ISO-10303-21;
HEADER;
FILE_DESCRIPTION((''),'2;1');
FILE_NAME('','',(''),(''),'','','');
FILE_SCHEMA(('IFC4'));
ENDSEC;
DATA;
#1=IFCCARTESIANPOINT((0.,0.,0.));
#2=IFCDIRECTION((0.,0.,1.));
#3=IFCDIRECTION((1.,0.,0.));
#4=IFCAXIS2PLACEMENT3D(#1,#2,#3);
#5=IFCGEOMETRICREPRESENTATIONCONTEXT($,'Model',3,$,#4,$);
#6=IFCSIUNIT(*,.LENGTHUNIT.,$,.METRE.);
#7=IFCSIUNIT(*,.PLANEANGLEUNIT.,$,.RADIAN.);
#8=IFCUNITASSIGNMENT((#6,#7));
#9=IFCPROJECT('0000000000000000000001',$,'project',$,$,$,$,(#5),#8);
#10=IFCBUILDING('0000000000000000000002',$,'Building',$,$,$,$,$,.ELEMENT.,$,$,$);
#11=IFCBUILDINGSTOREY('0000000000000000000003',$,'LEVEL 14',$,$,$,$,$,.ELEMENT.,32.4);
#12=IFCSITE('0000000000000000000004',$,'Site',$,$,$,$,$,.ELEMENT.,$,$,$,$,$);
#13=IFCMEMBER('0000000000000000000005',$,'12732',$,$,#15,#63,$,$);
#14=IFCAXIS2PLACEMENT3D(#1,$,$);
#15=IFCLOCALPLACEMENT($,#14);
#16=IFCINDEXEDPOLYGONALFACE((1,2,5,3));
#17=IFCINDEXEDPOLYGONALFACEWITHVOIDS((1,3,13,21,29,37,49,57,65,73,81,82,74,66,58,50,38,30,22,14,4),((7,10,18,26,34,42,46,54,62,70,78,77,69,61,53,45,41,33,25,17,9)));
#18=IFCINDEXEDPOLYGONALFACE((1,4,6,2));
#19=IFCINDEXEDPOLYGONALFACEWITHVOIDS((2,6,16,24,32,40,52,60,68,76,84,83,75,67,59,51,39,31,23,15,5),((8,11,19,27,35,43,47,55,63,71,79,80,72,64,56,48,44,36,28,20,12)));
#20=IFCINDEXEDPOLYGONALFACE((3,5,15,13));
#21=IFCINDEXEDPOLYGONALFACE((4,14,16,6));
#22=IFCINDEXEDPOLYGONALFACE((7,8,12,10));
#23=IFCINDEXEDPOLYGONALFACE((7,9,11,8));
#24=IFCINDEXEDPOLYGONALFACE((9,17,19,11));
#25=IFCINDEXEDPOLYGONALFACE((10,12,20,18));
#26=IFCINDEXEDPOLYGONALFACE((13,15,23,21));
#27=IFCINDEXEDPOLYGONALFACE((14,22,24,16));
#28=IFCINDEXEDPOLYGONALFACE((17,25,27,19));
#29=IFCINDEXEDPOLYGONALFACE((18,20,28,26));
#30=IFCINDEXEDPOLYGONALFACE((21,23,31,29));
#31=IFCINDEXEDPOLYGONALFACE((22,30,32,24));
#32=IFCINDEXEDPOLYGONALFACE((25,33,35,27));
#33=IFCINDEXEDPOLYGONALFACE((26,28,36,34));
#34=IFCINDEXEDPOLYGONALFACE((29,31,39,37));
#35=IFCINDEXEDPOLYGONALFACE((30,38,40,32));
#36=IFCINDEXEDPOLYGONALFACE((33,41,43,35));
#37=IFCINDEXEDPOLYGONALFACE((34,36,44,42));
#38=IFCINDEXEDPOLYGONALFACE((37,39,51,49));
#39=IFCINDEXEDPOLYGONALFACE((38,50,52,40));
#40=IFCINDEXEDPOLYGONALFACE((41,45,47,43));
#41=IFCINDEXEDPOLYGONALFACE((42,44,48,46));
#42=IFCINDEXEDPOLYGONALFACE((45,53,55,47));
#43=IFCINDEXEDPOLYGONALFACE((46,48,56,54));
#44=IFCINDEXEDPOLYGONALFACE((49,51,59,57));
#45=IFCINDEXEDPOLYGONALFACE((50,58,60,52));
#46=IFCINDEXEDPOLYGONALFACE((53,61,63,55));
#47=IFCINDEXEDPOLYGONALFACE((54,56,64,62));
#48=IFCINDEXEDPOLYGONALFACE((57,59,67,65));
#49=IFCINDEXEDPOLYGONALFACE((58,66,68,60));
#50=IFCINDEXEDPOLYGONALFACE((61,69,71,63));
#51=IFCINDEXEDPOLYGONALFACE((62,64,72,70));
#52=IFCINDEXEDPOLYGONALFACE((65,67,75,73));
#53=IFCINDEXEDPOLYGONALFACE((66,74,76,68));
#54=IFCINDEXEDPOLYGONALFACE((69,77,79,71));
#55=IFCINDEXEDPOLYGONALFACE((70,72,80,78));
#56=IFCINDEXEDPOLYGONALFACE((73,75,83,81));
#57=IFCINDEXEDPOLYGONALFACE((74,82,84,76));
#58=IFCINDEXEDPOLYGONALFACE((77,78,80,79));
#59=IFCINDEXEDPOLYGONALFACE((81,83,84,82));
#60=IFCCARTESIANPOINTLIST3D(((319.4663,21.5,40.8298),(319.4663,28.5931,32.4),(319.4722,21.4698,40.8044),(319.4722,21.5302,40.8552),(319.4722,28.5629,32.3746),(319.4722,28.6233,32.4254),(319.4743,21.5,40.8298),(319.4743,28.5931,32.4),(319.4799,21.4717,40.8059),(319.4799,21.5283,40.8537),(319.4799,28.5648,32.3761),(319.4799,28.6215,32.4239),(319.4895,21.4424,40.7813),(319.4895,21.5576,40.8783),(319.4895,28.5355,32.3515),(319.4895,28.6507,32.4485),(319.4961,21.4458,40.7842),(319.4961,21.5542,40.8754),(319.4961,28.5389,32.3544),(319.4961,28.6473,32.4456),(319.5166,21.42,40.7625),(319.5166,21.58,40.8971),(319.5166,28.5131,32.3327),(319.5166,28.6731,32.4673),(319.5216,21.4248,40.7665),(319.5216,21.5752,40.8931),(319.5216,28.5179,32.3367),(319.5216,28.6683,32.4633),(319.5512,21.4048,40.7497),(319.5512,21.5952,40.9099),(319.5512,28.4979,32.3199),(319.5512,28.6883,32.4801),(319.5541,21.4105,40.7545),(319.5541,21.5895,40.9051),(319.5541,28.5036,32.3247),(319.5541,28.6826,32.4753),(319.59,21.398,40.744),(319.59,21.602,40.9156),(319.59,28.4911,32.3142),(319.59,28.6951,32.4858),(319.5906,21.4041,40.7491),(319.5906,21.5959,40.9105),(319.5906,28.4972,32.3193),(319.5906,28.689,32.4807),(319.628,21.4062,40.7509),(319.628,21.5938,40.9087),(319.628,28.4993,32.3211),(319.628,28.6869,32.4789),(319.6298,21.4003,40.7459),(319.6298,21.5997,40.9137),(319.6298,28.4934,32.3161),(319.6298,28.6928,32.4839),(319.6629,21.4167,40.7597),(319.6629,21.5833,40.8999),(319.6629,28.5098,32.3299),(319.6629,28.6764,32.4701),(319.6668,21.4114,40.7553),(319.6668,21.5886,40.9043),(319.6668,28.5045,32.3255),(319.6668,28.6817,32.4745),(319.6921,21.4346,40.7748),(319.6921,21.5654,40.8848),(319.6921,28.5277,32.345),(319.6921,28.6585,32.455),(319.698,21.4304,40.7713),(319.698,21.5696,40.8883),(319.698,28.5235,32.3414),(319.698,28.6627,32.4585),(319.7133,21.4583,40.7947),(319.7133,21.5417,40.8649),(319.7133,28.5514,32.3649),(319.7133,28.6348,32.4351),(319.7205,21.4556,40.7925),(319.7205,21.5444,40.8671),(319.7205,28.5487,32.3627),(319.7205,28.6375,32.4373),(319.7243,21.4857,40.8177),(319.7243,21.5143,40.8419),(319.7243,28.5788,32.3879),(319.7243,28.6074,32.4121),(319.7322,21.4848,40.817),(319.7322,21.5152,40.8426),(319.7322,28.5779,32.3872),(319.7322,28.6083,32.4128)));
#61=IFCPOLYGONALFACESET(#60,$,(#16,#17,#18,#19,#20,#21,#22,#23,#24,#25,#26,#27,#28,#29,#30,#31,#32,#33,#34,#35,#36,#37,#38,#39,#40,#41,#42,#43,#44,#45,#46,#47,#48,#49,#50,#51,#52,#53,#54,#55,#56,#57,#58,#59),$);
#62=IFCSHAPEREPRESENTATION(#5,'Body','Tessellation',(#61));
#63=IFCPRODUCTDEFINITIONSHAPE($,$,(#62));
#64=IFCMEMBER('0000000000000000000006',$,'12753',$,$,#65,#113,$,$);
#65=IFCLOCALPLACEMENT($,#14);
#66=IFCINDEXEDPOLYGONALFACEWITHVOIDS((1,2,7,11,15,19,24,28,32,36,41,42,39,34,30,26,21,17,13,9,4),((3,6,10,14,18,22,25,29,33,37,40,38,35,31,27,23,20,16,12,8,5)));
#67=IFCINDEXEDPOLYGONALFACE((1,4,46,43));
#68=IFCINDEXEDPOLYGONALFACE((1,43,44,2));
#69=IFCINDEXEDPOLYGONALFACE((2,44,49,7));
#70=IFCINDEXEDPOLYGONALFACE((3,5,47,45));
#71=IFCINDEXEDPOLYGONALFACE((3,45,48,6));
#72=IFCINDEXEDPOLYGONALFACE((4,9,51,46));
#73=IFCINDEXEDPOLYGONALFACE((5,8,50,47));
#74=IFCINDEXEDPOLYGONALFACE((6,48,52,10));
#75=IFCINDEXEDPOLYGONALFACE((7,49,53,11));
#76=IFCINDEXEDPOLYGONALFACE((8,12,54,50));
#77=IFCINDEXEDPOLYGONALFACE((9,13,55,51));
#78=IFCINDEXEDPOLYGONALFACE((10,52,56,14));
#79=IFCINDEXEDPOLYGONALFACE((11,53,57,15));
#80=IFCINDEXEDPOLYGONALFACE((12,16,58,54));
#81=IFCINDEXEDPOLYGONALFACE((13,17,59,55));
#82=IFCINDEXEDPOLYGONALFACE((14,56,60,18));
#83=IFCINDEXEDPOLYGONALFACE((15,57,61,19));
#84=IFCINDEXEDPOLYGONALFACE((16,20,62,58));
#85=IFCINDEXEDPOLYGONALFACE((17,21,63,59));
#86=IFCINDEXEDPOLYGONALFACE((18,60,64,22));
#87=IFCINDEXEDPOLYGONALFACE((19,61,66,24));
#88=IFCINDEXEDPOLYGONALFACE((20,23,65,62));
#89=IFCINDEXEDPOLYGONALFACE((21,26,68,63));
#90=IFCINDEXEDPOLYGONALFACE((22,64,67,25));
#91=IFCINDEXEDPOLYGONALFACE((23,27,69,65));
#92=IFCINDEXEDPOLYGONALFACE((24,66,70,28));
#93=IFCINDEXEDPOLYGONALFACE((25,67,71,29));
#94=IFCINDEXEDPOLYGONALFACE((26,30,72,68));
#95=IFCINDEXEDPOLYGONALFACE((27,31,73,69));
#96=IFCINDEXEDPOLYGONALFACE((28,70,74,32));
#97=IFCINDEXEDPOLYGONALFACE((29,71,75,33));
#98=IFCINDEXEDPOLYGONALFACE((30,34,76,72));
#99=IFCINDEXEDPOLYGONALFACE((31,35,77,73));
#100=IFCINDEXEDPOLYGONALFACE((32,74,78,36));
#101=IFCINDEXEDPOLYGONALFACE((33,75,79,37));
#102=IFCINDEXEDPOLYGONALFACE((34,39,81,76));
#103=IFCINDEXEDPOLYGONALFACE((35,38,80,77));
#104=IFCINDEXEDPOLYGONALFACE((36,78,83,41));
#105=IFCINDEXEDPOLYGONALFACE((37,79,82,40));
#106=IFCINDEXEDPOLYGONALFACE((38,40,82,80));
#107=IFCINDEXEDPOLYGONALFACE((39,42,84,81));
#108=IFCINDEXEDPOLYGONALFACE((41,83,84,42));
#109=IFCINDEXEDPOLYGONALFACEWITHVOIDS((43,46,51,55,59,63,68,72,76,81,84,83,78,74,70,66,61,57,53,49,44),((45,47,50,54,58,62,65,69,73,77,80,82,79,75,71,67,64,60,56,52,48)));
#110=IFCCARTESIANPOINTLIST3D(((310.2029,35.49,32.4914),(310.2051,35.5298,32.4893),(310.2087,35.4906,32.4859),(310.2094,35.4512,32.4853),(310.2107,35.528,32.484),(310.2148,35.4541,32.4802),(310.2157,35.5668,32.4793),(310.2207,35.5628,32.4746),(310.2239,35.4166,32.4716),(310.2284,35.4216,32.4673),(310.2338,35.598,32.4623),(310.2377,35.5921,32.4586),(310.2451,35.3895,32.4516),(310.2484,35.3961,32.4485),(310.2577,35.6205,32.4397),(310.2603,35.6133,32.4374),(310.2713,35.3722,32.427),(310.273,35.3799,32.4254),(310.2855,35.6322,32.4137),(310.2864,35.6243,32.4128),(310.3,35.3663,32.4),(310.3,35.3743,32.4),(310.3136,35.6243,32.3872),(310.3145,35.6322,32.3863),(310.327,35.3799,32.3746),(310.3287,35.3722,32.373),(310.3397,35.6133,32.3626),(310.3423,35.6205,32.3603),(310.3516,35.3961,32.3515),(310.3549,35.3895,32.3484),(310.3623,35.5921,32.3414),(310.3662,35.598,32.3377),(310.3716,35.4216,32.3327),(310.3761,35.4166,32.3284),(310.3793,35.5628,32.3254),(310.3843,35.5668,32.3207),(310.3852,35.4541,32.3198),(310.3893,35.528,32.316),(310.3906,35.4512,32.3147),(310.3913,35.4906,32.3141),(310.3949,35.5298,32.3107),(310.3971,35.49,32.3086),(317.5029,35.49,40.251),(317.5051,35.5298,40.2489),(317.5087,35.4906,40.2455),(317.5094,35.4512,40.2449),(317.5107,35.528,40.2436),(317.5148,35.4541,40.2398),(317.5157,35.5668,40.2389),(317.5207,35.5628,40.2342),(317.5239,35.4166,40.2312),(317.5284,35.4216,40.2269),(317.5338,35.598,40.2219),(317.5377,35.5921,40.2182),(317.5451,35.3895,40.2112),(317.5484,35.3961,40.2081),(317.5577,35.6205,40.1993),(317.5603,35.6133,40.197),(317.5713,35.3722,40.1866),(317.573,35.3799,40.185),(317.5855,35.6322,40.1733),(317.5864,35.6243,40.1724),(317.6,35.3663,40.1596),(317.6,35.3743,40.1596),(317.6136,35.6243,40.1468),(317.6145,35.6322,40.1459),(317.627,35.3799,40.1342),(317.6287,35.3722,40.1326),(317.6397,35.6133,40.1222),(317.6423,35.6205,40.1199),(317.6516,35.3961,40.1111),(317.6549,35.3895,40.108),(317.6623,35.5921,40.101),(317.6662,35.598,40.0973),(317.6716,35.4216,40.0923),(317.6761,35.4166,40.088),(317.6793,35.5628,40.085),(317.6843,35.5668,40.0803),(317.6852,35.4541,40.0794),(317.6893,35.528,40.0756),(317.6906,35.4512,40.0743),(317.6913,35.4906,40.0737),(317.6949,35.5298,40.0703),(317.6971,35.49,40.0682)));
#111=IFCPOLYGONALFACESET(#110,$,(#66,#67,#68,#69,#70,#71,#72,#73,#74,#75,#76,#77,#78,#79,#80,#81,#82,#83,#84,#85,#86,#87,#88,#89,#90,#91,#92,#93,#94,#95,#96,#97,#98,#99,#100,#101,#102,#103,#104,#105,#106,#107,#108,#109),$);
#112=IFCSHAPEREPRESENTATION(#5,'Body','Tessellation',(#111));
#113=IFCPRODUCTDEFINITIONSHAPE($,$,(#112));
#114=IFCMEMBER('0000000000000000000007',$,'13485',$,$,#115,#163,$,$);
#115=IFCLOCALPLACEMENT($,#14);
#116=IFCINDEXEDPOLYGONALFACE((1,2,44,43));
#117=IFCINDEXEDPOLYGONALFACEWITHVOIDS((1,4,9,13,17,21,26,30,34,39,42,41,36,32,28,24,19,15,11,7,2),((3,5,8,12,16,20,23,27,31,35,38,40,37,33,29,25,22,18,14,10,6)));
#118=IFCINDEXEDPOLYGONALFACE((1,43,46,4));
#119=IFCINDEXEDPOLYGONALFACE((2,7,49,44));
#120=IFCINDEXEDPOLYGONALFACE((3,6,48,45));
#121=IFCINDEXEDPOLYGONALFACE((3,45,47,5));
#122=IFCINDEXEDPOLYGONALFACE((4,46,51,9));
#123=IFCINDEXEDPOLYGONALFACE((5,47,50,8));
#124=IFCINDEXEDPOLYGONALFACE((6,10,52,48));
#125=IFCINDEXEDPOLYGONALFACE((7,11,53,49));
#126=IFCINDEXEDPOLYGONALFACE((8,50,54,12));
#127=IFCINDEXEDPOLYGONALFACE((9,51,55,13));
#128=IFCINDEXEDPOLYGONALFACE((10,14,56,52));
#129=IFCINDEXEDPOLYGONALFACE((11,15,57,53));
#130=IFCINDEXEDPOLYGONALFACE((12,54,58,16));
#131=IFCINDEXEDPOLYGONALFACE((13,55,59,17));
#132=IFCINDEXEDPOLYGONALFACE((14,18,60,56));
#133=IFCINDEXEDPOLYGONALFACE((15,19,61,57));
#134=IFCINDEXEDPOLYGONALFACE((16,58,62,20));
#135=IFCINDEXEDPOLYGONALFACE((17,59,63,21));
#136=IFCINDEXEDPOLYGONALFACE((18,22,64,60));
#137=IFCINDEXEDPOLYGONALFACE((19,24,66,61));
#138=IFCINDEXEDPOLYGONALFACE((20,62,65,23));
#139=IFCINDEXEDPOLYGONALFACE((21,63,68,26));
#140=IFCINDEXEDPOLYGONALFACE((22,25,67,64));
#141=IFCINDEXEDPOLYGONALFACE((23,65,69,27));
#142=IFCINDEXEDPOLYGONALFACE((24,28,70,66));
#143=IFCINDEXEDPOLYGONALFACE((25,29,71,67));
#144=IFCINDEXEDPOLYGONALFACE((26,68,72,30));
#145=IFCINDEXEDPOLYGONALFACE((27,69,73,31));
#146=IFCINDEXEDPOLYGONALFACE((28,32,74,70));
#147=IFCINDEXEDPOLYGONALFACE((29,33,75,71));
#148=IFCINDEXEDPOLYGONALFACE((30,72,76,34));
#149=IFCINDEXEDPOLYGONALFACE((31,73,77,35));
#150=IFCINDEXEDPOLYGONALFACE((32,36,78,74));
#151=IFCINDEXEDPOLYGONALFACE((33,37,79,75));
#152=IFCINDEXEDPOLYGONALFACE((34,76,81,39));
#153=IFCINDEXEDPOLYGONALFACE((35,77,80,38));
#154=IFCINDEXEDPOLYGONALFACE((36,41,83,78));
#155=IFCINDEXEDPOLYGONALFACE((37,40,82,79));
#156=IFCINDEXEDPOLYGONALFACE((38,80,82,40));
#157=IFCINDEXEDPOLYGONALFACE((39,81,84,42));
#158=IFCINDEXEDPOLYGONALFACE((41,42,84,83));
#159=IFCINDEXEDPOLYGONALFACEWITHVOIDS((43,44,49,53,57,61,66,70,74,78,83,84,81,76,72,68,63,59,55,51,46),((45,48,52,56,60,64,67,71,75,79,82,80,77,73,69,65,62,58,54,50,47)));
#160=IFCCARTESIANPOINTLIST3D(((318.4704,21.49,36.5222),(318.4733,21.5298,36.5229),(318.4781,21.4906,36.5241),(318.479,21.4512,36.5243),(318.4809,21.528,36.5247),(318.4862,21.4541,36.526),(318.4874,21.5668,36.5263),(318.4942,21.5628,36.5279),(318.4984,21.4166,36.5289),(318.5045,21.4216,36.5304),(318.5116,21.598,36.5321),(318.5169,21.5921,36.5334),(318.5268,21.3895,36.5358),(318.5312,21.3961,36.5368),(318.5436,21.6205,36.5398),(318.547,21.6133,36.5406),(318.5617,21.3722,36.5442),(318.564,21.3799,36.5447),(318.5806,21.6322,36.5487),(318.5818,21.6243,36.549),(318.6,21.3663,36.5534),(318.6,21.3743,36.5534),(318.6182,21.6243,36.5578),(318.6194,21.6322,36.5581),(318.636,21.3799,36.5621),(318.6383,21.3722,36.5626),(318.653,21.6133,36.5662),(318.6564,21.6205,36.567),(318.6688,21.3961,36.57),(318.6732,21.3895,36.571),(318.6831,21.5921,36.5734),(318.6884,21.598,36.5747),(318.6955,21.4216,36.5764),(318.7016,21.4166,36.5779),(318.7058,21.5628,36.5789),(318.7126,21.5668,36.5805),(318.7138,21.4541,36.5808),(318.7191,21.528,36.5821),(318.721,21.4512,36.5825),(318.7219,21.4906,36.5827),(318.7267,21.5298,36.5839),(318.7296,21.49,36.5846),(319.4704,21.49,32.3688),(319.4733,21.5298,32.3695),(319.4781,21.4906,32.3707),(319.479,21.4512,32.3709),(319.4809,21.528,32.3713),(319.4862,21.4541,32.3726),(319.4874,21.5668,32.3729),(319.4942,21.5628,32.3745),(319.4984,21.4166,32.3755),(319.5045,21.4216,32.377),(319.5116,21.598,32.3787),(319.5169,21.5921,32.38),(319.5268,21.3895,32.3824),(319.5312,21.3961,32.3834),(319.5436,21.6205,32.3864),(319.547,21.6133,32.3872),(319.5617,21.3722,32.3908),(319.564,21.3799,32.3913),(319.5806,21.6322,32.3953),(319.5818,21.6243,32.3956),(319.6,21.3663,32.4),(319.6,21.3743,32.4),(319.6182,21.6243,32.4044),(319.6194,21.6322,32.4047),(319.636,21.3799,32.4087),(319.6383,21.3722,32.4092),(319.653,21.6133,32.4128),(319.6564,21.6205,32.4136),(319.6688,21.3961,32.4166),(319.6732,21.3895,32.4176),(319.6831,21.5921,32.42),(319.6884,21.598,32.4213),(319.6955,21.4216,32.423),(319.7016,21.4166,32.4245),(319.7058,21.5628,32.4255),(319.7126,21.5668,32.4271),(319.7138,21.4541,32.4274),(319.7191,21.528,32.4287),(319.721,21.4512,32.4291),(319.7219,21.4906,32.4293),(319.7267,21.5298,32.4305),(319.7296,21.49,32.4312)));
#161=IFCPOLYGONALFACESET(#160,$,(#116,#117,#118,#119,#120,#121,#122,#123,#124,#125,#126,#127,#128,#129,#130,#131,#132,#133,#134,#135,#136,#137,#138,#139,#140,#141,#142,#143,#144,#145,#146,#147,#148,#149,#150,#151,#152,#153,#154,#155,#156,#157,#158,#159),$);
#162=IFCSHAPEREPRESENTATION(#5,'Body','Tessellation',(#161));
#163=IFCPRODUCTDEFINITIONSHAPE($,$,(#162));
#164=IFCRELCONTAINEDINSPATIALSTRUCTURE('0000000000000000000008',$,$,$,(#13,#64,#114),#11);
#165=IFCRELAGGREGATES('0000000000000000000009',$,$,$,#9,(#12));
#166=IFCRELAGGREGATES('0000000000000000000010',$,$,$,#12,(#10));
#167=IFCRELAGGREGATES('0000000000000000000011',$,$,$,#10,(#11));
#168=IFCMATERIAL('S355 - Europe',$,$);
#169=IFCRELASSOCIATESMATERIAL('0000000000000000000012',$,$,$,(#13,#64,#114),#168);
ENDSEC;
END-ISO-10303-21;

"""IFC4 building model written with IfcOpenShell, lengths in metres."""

from ifc_helpers import new_model, si_unit, frame, origin_with_axes, origin_2d_with_axis, place, context, project, spatial, hollow_circle, extrude, material, material_profile, profile_set, profile_usage, element, save


model = new_model("IFC4")

# Units and contexts
model_context = context("Model", 3, world=origin_with_axes())
ifc_project = project(units=[si_unit("LENGTHUNIT", "METRE"), si_unit("PLANEANGLEUNIT", "RADIAN")], contexts=[model_context])

# Site, building, storey
site = spatial("IfcSite", under=ifc_project, Name="Site", CompositionType="ELEMENT")
building = spatial("IfcBuilding", under=site, Name="Building", CompositionType="ELEMENT")
storey = spatial("IfcBuildingStorey", under=building, Name="LEVEL 14", CompositionType="ELEMENT", Elevation=32.4)

# Shared definitions
ifc_material = material(Name="S355 - Europe")

# Members
ifc_material_profile_1 = material_profile(ifc_material, hollow_circle(Radius=0.1337, WallThickness=0.008, at=origin_2d_with_axis()))
ifc_profile_set_1 = profile_set([ifc_material_profile_1])
ifc_profile_usage_1 = profile_usage(ifc_profile_set_1, cardinal=10)
member_1_placement = place(None, frame((319.6, 21.5, 40.8298), z_axis=(0.0, 0.643834, -0.765165), x_axis=(-1.0, 0.0, 0.0)))
element("IfcMember", 1, at=member_1_placement, inside=storey, material=ifc_profile_usage_1, Name="12732", context=model_context, shape_type="SweptSolid", body=[
    extrude(hollow_circle(Radius=0.1337, WallThickness=0.008, at=origin_2d_with_axis()), origin_with_axes(), (0.0, 0.0, 1.0), 11.017),
])
ifc_material_profile_2 = material_profile(ifc_material, hollow_circle(Radius=0.1337, WallThickness=0.008, at=origin_2d_with_axis()))
ifc_profile_set_2 = profile_set([ifc_material_profile_2])
ifc_profile_usage_2 = profile_usage(ifc_profile_set_2, cardinal=10)
member_2_placement = place(None, frame((317.6, 35.5, 40.1596), z_axis=(-0.685208, 0.0, -0.728348), x_axis=(0.0, -1.0, 0.0)))
element("IfcMember", 2, at=member_2_placement, inside=storey, material=ifc_profile_usage_2, Name="12753", context=model_context, shape_type="SweptSolid", body=[
    extrude(hollow_circle(Radius=0.1337, WallThickness=0.008, at=origin_2d_with_axis()), origin_with_axes(), (0.0, 0.0, 1.0), 10.6537),
])
ifc_material_profile_3 = material_profile(ifc_material, hollow_circle(Radius=0.1337, WallThickness=0.008, at=origin_2d_with_axis()))
ifc_profile_set_3 = profile_set([ifc_material_profile_3])
ifc_profile_usage_3 = profile_usage(ifc_profile_set_3, cardinal=10)
member_3_placement = place(None, frame((319.6, 21.5, 32.4), z_axis=(-0.234078, 0.0, 0.972218), x_axis=(0.0, -1.0, 0.0)))
element("IfcMember", 3, at=member_3_placement, inside=storey, material=ifc_profile_usage_3, Name="13485", context=model_context, shape_type="SweptSolid", body=[
    extrude(hollow_circle(Radius=0.1337, WallThickness=0.008, at=origin_2d_with_axis()), origin_with_axes(), (0.0, 0.0, 1.0), 4.2721),
])

save(model, "model.ifc")
